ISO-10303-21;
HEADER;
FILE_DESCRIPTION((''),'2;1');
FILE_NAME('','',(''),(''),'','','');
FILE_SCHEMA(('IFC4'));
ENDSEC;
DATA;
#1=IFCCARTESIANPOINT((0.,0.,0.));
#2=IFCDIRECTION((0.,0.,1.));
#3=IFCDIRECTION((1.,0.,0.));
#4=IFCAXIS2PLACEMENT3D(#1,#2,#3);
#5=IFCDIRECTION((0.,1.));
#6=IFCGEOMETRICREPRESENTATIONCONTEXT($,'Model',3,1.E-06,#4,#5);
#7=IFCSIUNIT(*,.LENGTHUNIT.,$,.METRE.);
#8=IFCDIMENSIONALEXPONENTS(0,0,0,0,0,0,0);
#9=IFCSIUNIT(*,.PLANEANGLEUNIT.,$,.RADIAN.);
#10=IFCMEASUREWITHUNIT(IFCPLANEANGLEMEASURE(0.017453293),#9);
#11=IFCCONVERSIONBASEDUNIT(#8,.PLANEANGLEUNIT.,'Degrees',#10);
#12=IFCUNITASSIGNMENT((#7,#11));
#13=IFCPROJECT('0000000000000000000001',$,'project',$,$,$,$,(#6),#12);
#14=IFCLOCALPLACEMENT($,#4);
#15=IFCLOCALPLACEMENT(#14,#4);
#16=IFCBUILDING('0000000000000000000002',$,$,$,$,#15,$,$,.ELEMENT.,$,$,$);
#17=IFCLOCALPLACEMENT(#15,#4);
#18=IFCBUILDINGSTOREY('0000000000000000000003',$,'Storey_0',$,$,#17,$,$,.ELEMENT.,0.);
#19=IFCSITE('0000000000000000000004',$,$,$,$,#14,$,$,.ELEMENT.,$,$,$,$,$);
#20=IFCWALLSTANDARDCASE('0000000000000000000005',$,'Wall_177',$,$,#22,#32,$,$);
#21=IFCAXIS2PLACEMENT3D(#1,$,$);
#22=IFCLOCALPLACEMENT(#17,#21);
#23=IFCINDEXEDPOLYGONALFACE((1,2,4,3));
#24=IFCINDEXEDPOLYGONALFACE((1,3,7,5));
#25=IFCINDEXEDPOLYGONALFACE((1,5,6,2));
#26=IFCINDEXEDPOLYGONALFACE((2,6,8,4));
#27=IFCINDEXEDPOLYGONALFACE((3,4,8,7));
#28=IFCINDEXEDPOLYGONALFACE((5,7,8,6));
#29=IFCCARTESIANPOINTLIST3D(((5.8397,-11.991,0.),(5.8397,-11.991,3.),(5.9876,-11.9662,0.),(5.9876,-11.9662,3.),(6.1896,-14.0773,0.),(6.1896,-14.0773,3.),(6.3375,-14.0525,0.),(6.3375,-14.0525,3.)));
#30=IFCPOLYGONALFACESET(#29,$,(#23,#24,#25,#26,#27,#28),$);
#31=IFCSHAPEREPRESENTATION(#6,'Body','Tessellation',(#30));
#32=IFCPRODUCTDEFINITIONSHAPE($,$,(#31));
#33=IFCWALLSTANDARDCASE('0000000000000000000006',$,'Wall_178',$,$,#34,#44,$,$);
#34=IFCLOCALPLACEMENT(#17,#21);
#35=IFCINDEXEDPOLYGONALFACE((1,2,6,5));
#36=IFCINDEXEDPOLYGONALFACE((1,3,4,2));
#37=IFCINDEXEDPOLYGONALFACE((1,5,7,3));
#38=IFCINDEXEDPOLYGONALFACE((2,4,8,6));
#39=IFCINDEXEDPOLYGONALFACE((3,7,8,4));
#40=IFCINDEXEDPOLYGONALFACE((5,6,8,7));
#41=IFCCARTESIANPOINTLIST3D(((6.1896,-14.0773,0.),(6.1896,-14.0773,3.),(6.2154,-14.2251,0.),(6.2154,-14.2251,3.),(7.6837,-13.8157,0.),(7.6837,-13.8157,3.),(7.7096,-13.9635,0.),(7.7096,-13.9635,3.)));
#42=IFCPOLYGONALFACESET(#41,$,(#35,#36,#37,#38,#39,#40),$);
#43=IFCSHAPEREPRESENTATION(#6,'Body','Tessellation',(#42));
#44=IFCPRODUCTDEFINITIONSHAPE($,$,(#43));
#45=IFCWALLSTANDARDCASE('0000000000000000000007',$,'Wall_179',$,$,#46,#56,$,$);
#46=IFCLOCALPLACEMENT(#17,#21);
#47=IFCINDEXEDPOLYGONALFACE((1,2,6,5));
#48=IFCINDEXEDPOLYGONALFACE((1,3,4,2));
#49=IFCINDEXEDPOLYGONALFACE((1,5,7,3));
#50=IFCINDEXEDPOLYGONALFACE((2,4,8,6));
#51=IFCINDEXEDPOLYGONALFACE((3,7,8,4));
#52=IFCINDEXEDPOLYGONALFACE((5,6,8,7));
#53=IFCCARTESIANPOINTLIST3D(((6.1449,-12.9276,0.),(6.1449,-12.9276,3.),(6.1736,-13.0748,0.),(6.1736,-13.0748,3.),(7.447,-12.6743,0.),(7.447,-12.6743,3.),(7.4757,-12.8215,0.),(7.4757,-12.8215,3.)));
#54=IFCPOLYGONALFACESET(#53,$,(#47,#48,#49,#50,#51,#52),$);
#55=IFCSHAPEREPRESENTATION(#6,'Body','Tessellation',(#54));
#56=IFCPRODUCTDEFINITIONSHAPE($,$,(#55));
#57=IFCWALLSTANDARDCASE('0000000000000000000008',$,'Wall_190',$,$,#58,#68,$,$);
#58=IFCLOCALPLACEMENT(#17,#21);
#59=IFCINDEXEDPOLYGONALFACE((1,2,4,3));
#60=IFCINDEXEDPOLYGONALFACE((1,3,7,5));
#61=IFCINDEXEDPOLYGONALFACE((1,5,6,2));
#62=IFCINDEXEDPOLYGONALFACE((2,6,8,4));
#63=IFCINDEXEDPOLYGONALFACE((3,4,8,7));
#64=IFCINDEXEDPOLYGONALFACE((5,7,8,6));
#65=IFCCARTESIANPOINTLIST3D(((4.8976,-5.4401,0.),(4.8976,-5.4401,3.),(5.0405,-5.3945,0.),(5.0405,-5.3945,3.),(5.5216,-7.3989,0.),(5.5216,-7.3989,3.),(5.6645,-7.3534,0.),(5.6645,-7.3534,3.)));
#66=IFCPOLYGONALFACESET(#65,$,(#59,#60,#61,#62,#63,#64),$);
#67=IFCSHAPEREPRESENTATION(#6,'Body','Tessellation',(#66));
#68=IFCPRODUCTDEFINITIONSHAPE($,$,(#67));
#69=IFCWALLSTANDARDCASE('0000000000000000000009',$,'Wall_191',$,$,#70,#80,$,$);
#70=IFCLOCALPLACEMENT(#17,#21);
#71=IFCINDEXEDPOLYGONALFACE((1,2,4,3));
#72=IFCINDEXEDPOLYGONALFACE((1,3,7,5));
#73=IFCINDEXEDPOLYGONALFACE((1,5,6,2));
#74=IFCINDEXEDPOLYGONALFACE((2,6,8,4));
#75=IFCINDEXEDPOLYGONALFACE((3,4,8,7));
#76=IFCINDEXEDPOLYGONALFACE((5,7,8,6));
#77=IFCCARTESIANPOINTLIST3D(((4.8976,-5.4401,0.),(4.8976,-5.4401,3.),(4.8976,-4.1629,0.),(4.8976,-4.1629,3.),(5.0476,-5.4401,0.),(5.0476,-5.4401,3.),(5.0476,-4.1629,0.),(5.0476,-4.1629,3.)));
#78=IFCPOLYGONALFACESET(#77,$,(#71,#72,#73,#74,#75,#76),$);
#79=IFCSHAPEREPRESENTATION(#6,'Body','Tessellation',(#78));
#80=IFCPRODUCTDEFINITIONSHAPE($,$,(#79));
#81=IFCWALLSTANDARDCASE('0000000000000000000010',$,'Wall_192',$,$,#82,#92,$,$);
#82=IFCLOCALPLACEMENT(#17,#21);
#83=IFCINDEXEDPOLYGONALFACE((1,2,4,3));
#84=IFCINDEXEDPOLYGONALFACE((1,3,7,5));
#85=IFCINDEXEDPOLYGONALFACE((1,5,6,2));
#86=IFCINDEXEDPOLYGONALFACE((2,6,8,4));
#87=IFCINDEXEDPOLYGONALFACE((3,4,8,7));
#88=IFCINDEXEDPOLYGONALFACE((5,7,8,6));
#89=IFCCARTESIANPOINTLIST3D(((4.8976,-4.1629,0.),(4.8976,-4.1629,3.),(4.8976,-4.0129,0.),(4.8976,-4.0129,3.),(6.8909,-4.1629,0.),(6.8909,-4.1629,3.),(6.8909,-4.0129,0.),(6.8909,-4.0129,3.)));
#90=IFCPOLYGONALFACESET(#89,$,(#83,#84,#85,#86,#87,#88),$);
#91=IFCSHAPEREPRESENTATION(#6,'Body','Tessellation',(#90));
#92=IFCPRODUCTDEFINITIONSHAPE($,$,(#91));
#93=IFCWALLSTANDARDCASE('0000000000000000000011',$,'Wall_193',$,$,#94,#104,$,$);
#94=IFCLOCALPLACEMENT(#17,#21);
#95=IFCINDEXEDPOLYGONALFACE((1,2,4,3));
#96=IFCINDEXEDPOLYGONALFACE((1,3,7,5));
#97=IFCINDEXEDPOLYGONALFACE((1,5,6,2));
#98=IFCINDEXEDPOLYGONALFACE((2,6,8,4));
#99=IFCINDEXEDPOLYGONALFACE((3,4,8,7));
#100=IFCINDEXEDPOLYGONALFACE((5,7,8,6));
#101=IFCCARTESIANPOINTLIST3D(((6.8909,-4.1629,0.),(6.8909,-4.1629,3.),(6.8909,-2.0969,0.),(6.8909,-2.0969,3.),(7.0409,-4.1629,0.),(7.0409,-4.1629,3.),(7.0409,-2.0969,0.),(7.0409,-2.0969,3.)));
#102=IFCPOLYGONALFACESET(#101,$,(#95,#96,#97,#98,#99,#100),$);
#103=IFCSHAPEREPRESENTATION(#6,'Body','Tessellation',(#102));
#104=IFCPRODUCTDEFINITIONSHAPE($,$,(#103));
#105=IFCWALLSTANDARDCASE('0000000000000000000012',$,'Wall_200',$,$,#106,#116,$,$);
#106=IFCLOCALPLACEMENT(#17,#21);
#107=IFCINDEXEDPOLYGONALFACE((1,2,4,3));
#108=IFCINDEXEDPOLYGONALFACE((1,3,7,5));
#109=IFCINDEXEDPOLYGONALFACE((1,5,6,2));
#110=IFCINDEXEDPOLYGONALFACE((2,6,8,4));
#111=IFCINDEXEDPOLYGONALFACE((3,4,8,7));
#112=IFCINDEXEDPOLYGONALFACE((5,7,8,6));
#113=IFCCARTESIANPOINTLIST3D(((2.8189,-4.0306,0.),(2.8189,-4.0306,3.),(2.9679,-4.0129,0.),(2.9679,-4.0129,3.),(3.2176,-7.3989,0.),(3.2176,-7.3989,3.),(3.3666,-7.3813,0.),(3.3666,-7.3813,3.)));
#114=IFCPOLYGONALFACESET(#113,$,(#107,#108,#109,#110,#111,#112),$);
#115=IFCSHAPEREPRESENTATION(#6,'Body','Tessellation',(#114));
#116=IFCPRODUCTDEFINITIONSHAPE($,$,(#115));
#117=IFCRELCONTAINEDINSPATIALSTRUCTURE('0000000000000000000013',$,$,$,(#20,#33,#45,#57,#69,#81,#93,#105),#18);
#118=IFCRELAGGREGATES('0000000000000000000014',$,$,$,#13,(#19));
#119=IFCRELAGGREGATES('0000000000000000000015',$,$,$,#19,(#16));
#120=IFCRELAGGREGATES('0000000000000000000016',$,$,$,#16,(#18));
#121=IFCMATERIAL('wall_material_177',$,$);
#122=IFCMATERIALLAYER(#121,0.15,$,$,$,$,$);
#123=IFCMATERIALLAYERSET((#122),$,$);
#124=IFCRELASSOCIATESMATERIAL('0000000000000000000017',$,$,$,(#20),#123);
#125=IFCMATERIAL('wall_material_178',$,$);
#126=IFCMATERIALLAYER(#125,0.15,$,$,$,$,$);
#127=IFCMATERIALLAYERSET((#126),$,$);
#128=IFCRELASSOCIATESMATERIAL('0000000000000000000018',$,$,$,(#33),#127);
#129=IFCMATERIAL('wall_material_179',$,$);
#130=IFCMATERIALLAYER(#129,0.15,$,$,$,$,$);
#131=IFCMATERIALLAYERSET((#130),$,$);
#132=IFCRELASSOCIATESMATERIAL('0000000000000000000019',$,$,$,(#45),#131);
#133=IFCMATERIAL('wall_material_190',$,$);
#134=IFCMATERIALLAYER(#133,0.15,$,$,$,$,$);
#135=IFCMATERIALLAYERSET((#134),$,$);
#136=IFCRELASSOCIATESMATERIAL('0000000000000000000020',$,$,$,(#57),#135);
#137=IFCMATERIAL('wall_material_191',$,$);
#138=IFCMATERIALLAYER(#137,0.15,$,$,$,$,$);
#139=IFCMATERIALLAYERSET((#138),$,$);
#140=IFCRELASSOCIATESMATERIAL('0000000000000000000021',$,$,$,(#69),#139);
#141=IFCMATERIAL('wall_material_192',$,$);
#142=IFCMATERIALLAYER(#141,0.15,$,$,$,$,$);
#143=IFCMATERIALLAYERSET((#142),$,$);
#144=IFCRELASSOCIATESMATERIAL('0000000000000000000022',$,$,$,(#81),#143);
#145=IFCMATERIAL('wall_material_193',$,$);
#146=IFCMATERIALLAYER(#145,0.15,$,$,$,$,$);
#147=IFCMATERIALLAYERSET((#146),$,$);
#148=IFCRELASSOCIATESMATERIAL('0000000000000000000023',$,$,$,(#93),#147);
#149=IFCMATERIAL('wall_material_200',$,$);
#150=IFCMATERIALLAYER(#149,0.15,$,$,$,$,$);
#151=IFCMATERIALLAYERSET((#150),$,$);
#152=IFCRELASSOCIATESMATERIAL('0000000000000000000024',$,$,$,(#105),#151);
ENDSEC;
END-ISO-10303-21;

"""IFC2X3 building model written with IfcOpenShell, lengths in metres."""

from ifc_helpers import new_model, entity, si_unit, converted_unit, direction, frame, origin_with_axes, place, context, project, spatial, polyline, outline, extrude, material, layer, layer_set, layer_usage, element, save


model = new_model("IFC2X3")

# Units and contexts
model_context = context("Model", 3, precision=1e-06, world=origin_with_axes(), true_north=direction((0.0, 1.0)))
ifc_project = project(units=[si_unit("LENGTHUNIT", "METRE"), converted_unit("PLANEANGLEUNIT", "Degrees", entity("IfcPlaneAngleMeasure", 0.017453293), si_unit("PLANEANGLEUNIT", "RADIAN"), dimensions=[0, 0, 0, 0, 0, 0, 0])], contexts=[model_context])

# Site, building, storey
site_placement = place(None, origin_with_axes())
site = spatial("IfcSite", under=ifc_project, at=site_placement, CompositionType="ELEMENT")
building_placement = place(site_placement, origin_with_axes())
building = spatial("IfcBuilding", under=site, at=building_placement, CompositionType="ELEMENT")
storey_placement = place(building_placement, origin_with_axes())
storey = spatial("IfcBuildingStorey", under=building, at=storey_placement, Name="Storey_0", CompositionType="ELEMENT", Elevation=0.0)

# Walls
ifc_material_1 = material(Name="wall_material_177")
ifc_layer_1 = layer(ifc_material_1, 0.15)
ifc_layer_set_1 = layer_set([ifc_layer_1])
ifc_layer_usage_1 = layer_usage(ifc_layer_set_1, "AXIS2", "NEGATIVE", 0.0)
wall_1_placement = place(storey_placement, frame((5.9876, -11.9662, 0.0), z_axis=(0.0, 0.0, 1.0), x_axis=(0.165392, -0.986228, 0.0)))
element("IfcWallStandardCase", 1, at=wall_1_placement, inside=storey, material=ifc_layer_usage_1, Name="Wall_177", context=model_context, shape_type="SweptSolid", body=[
    extrude(outline(polyline([(0.0, 0.0), (2.1155, 0.0), (2.1155, -0.15), (0.0, -0.15), (0.0, 0.0)])), origin_with_axes(), (0.0, 0.0, 1.0), 3.0),
])
ifc_material_2 = material(Name="wall_material_178")
ifc_layer_2 = layer(ifc_material_2, 0.15)
ifc_layer_set_2 = layer_set([ifc_layer_2])
ifc_layer_usage_2 = layer_usage(ifc_layer_set_2, "AXIS2", "NEGATIVE", 0.0)
wall_2_placement = place(storey_placement, frame((6.1896, -14.0773, 0.0), z_axis=(0.0, 0.0, 1.0), x_axis=(0.985019, 0.172445, 0.0)))
element("IfcWallStandardCase", 2, at=wall_2_placement, inside=storey, material=ifc_layer_usage_2, Name="Wall_178", context=model_context, shape_type="SweptSolid", body=[
    extrude(outline(polyline([(0.0, 0.0), (1.5169, 0.0), (1.5169, -0.15), (0.0, -0.15), (0.0, 0.0)])), origin_with_axes(), (0.0, 0.0, 1.0), 3.0),
])
ifc_material_3 = material(Name="wall_material_179")
ifc_layer_3 = layer(ifc_material_3, 0.15)
ifc_layer_set_3 = layer_set([ifc_layer_3])
ifc_layer_usage_3 = layer_usage(ifc_layer_set_3, "AXIS2", "NEGATIVE", 0.0)
wall_3_placement = place(storey_placement, frame((7.4757, -12.8215, 0.0), z_axis=(0.0, 0.0, 1.0), x_axis=(-0.981594, -0.19098, 0.0)))
element("IfcWallStandardCase", 3, at=wall_3_placement, inside=storey, material=ifc_layer_usage_3, Name="Wall_179", context=model_context, shape_type="SweptSolid", body=[
    extrude(outline(polyline([(0.0, 0.0), (1.3265, 0.0), (1.3265, -0.15), (0.0, -0.15), (0.0, 0.0)])), origin_with_axes(), (0.0, 0.0, 1.0), 3.0),
])
ifc_material_4 = material(Name="wall_material_190")
ifc_layer_4 = layer(ifc_material_4, 0.15)
ifc_layer_set_4 = layer_set([ifc_layer_4])
ifc_layer_usage_4 = layer_usage(ifc_layer_set_4, "AXIS2", "NEGATIVE", 0.0)
wall_4_placement = place(storey_placement, frame((5.5216, -7.3989, 0.0), z_axis=(0.0, 0.0, 1.0), x_axis=(-0.303534, 0.952821, 0.0)))
element("IfcWallStandardCase", 4, at=wall_4_placement, inside=storey, material=ifc_layer_usage_4, Name="Wall_190", context=model_context, shape_type="SweptSolid", body=[
    extrude(outline(polyline([(0.0, 0.0), (2.0558, 0.0), (2.0558, -0.15), (0.0, -0.15), (0.0, 0.0)])), origin_with_axes(), (0.0, 0.0, 1.0), 3.0),
])
ifc_material_5 = material(Name="wall_material_191")
ifc_layer_5 = layer(ifc_material_5, 0.15)
ifc_layer_set_5 = layer_set([ifc_layer_5])
ifc_layer_usage_5 = layer_usage(ifc_layer_set_5, "AXIS2", "NEGATIVE", 0.0)
wall_5_placement = place(storey_placement, frame((4.8976, -5.4401, 0.0), z_axis=(0.0, 0.0, 1.0), x_axis=(0.0, 1.0, 0.0)))
element("IfcWallStandardCase", 5, at=wall_5_placement, inside=storey, material=ifc_layer_usage_5, Name="Wall_191", context=model_context, shape_type="SweptSolid", body=[
    extrude(outline(polyline([(0.0, 0.0), (1.2771, 0.0), (1.2771, -0.15), (0.0, -0.15), (0.0, 0.0)])), origin_with_axes(), (0.0, 0.0, 1.0), 3.0),
])
ifc_material_6 = material(Name="wall_material_192")
ifc_layer_6 = layer(ifc_material_6, 0.15)
ifc_layer_set_6 = layer_set([ifc_layer_6])
ifc_layer_usage_6 = layer_usage(ifc_layer_set_6, "AXIS2", "NEGATIVE", 0.0)
wall_6_placement = place(storey_placement, frame((4.8976, -4.0129, 0.0), z_axis=(0.0, 0.0, 1.0), x_axis=(1.0, 0.0, 0.0)))
element("IfcWallStandardCase", 6, at=wall_6_placement, inside=storey, material=ifc_layer_usage_6, Name="Wall_192", context=model_context, shape_type="SweptSolid", body=[
    extrude(outline(polyline([(0.0, 0.0), (1.9932, 0.0), (1.9932, -0.15), (0.0, -0.15), (0.0, 0.0)])), origin_with_axes(), (0.0, 0.0, 1.0), 3.0),
])
ifc_material_7 = material(Name="wall_material_193")
ifc_layer_7 = layer(ifc_material_7, 0.15)
ifc_layer_set_7 = layer_set([ifc_layer_7])
ifc_layer_usage_7 = layer_usage(ifc_layer_set_7, "AXIS2", "NEGATIVE", 0.0)
wall_7_placement = place(storey_placement, frame((6.8909, -4.1629, 0.0), z_axis=(0.0, 0.0, 1.0), x_axis=(0.0, 1.0, 0.0)))
element("IfcWallStandardCase", 7, at=wall_7_placement, inside=storey, material=ifc_layer_usage_7, Name="Wall_193", context=model_context, shape_type="SweptSolid", body=[
    extrude(outline(polyline([(0.0, 0.0), (2.066, 0.0), (2.066, -0.15), (0.0, -0.15), (0.0, 0.0)])), origin_with_axes(), (0.0, 0.0, 1.0), 3.0),
])
ifc_material_8 = material(Name="wall_material_200")
ifc_layer_8 = layer(ifc_material_8, 0.15)
ifc_layer_set_8 = layer_set([ifc_layer_8])
ifc_layer_usage_8 = layer_usage(ifc_layer_set_8, "AXIS2", "NEGATIVE", 0.0)
wall_8_placement = place(storey_placement, frame((3.2176, -7.3989, 0.0), z_axis=(0.0, 0.0, 1.0), x_axis=(-0.117537, 0.993068, 0.0)))
element("IfcWallStandardCase", 8, at=wall_8_placement, inside=storey, material=ifc_layer_usage_8, Name="Wall_200", context=model_context, shape_type="SweptSolid", body=[
    extrude(outline(polyline([(0.0, 0.0), (3.3919, 0.0), (3.3919, -0.15), (0.0, -0.15), (0.0, 0.0)])), origin_with_axes(), (0.0, 0.0, 1.0), 3.0),
])

save(model, "model.ifc")
